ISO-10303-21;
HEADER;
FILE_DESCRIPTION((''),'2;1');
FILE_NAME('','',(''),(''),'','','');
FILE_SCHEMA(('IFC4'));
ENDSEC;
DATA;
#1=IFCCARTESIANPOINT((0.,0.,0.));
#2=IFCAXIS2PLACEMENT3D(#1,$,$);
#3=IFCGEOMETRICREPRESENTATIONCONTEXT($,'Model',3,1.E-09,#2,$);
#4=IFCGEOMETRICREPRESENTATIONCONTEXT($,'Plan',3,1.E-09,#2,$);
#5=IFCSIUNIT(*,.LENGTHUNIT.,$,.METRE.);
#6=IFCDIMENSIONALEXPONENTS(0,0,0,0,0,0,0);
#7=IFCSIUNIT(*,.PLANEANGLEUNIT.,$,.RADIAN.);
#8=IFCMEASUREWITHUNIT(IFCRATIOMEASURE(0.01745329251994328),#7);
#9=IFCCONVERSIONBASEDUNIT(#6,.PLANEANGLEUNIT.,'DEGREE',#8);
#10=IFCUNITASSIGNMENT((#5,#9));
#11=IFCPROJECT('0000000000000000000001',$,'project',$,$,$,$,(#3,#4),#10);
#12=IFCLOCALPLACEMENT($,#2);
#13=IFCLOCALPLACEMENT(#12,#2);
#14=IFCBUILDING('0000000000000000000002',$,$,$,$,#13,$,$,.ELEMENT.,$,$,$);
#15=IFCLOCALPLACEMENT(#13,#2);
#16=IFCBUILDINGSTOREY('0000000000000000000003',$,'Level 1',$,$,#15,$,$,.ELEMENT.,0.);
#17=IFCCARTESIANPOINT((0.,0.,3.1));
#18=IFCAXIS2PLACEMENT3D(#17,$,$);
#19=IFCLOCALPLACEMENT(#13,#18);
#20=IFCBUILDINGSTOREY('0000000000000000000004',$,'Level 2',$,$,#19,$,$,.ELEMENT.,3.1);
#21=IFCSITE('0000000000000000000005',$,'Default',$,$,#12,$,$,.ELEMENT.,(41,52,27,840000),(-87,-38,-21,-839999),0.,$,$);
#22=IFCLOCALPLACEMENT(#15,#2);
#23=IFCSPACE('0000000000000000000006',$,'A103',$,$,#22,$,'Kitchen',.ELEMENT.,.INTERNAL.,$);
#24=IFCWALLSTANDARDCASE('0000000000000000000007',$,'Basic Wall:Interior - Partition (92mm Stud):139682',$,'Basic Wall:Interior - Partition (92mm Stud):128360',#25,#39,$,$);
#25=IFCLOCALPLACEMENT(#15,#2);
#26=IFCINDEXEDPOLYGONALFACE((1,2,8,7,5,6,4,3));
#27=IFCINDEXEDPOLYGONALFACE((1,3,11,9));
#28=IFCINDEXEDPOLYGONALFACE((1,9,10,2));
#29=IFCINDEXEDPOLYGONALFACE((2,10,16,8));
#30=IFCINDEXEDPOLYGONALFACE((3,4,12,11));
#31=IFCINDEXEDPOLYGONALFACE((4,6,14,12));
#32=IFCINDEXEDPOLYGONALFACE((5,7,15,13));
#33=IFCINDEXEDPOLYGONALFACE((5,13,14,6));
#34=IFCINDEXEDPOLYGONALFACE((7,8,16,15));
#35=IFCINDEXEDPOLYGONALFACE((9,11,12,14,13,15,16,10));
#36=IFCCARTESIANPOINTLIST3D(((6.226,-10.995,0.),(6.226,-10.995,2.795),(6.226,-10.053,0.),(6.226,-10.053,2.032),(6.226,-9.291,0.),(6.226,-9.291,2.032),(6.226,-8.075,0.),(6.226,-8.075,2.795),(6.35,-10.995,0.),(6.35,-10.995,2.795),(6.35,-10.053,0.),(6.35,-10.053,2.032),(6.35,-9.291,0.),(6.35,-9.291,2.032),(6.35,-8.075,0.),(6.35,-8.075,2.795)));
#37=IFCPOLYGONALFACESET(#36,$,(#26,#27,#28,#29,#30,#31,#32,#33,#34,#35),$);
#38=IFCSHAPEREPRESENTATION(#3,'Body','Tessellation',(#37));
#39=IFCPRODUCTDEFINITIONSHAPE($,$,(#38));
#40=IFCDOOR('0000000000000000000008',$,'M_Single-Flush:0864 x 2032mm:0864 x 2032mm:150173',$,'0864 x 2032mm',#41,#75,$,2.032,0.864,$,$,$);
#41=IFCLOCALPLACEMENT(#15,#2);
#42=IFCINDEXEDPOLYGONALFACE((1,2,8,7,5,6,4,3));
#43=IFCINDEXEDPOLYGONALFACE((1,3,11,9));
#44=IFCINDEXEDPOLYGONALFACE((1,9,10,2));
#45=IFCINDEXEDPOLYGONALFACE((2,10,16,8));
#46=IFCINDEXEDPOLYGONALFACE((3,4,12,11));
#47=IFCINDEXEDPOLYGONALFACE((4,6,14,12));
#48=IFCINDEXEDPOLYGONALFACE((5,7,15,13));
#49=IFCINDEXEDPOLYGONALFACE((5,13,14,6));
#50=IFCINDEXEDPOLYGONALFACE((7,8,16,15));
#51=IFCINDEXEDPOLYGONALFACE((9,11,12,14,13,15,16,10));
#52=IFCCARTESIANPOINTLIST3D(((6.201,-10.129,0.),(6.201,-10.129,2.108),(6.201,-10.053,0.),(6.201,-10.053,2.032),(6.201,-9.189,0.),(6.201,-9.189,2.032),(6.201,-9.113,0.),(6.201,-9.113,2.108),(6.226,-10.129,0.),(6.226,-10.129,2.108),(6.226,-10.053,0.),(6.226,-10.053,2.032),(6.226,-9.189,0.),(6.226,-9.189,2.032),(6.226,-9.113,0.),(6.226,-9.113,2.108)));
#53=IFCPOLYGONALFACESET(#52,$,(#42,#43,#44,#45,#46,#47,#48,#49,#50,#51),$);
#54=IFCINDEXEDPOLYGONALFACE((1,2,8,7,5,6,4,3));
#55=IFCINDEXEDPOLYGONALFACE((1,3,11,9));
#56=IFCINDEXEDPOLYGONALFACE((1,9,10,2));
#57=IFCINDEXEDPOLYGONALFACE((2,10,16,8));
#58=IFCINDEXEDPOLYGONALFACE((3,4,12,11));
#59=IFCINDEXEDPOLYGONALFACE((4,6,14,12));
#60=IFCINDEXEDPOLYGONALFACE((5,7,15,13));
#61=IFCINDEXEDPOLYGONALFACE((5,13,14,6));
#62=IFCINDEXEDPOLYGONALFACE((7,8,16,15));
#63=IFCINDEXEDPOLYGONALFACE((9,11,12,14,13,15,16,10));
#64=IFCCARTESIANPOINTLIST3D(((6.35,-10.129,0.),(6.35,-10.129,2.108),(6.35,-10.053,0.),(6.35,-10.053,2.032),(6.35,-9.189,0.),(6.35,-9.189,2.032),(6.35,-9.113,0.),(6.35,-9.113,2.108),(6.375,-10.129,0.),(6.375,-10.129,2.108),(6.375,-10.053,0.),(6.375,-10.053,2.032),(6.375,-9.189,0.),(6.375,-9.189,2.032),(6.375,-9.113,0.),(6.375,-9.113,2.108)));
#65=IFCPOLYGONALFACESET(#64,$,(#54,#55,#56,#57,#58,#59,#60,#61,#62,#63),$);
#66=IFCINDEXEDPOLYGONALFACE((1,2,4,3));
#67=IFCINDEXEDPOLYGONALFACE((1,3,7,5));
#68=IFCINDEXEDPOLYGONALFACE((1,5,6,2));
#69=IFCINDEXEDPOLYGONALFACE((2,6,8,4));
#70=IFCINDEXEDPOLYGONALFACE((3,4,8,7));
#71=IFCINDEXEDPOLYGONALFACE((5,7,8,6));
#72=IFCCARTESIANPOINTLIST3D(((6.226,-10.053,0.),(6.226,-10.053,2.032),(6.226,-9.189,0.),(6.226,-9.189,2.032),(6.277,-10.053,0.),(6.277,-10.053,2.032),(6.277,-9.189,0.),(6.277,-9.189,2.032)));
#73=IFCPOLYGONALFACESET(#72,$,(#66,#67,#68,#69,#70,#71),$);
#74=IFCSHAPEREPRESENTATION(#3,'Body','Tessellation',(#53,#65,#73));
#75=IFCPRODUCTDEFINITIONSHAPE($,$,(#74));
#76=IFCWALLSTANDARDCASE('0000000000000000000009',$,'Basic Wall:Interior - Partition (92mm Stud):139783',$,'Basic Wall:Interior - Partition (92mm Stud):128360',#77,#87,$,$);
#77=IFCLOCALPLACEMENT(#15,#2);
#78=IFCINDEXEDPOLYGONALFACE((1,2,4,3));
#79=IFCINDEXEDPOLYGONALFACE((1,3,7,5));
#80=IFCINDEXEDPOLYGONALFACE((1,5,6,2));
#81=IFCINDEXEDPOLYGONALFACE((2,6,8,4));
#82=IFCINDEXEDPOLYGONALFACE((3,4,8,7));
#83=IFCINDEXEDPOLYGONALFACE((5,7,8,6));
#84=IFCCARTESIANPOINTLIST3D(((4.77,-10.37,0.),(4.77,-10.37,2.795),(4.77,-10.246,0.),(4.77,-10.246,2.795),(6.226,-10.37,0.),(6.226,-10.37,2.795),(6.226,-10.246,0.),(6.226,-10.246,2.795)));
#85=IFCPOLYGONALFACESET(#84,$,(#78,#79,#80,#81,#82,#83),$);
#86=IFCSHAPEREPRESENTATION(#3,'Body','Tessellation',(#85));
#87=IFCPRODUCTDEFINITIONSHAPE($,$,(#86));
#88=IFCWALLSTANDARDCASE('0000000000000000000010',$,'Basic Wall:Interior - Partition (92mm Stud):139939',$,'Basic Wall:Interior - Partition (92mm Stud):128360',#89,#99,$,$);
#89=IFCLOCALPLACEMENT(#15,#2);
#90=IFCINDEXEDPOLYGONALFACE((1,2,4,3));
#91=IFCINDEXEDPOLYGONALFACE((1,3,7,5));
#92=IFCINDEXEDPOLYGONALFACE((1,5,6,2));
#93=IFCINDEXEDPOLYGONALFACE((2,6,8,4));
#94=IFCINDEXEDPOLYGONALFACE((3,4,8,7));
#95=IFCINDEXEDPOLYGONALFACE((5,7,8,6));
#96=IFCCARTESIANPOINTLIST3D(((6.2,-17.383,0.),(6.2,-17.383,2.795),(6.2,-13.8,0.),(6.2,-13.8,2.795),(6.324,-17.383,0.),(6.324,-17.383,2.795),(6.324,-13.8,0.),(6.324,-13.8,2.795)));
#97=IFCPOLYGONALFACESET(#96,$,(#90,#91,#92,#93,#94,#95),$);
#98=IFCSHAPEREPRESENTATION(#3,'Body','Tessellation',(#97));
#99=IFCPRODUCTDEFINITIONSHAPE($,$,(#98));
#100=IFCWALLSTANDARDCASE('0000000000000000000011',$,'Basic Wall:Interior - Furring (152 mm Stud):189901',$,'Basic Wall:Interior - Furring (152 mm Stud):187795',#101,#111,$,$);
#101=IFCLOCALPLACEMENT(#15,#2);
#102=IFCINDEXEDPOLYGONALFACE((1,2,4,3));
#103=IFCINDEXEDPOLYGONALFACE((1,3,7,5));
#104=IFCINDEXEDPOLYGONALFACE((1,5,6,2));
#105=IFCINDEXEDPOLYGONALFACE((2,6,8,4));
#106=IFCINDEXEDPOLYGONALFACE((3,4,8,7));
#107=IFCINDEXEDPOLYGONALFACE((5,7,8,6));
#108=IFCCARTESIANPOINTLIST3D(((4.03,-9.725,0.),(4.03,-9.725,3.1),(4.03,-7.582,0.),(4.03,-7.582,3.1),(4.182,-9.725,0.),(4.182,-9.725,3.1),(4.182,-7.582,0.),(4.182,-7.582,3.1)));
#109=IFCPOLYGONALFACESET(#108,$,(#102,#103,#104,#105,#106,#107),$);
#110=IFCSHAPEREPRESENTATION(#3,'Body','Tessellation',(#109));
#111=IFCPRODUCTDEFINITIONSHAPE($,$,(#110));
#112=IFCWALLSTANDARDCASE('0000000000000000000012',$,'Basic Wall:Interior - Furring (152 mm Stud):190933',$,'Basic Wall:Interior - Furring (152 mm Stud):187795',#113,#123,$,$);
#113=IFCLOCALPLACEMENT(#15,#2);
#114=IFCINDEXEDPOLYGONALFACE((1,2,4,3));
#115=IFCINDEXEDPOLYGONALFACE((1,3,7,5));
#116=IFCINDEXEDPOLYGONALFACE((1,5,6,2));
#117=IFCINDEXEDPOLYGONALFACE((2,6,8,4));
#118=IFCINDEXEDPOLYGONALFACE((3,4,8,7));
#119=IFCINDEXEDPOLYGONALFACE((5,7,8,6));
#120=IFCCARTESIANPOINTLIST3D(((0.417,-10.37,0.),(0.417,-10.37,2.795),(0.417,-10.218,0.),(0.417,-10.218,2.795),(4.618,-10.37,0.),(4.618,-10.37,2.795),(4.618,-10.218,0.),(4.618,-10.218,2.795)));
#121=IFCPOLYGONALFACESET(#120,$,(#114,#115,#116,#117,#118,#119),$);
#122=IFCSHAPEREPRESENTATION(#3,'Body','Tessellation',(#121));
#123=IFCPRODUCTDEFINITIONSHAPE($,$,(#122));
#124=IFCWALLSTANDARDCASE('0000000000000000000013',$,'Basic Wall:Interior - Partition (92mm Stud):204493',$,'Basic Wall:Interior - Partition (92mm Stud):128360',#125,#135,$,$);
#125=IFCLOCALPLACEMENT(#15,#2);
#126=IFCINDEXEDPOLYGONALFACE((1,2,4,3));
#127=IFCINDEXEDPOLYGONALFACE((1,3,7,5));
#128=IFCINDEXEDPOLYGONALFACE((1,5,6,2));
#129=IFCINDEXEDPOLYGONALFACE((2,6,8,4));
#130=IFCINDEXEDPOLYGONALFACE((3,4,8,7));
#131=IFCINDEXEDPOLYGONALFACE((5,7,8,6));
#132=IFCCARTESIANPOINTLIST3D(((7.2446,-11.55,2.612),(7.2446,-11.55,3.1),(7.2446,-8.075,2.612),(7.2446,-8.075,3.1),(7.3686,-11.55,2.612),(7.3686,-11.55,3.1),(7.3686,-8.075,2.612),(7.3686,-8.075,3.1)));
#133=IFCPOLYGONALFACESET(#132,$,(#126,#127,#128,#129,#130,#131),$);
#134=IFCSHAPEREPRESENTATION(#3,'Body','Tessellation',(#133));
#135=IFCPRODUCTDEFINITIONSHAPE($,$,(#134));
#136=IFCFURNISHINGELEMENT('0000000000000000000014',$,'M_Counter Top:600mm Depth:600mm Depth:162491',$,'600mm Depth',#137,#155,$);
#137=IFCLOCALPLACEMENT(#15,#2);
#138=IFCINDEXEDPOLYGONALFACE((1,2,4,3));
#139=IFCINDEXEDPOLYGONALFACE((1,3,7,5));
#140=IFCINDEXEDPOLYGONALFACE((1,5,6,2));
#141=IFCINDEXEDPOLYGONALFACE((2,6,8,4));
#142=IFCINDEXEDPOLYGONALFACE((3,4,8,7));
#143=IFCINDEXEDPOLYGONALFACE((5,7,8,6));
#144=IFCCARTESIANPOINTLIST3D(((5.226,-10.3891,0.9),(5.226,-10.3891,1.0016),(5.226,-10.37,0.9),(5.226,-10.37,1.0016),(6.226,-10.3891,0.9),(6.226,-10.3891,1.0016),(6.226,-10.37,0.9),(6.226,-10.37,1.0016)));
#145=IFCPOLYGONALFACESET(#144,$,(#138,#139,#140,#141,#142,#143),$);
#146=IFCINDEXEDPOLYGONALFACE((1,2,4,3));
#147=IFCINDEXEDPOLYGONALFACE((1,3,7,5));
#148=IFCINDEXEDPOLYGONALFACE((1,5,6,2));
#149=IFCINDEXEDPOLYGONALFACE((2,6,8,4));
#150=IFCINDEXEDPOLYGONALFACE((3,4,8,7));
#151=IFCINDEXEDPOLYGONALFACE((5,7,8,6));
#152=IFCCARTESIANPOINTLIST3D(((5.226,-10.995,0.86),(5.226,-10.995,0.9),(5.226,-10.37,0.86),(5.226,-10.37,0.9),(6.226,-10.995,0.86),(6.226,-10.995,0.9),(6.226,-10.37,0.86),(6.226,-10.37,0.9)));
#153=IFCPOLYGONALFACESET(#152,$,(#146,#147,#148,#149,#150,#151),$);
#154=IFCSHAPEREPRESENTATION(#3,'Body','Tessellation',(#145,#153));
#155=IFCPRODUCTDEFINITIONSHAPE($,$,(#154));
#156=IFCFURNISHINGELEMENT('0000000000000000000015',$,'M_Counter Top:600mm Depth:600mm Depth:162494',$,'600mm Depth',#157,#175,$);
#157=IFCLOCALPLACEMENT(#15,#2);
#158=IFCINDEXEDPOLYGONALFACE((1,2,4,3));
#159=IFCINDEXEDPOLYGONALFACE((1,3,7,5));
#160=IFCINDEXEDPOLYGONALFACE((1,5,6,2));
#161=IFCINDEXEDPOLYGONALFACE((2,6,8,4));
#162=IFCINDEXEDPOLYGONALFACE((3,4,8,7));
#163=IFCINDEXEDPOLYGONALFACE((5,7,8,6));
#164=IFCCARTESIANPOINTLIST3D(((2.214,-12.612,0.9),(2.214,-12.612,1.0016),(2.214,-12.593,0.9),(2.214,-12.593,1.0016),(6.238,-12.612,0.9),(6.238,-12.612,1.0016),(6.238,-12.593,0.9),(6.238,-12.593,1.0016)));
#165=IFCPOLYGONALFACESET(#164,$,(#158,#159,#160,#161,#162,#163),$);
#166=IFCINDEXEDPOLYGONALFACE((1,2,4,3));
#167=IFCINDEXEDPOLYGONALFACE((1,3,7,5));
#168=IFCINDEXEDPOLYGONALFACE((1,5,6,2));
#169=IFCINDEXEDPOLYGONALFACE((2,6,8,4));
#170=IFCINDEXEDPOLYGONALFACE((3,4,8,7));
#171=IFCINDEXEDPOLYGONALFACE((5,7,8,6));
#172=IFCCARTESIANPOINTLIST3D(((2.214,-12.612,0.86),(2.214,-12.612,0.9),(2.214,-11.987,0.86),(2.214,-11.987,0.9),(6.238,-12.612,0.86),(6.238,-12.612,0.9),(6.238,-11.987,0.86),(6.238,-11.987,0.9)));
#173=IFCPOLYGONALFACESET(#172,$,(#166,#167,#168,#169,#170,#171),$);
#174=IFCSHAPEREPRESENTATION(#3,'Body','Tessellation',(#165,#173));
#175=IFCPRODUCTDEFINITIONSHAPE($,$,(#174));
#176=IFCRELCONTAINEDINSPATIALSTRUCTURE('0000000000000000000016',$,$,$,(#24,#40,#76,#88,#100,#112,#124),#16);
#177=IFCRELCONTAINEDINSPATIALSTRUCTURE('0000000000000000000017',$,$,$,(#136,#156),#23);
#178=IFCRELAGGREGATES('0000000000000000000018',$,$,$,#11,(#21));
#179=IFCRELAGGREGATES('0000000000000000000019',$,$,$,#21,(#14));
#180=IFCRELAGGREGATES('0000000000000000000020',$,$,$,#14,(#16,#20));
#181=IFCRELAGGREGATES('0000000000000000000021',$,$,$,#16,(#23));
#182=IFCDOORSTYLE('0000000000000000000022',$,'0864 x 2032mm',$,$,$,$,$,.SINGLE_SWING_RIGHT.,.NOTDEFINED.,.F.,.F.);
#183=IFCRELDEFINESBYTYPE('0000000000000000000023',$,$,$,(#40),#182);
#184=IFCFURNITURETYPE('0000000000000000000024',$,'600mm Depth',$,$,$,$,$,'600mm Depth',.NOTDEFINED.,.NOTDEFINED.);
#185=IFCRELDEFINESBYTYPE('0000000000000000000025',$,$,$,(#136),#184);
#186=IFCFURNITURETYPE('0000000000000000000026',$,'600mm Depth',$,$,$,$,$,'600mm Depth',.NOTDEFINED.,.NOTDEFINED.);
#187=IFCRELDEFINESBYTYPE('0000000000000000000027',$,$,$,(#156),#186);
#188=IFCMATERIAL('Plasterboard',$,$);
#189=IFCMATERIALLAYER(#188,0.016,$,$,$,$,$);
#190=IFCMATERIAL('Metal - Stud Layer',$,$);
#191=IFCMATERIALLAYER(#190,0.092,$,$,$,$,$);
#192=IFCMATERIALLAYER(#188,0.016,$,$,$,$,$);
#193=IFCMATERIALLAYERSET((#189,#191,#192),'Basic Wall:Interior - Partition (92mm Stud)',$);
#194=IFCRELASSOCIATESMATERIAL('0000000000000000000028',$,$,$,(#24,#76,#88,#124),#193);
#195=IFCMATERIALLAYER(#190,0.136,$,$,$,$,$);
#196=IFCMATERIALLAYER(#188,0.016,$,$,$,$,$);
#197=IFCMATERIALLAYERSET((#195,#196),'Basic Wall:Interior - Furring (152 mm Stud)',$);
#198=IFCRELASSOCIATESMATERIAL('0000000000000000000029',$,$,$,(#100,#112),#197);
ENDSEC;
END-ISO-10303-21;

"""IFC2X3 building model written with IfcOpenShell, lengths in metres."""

from ifc_helpers import new_model, entity, si_unit, converted_unit, frame, frame_2d, origin, origin_2d_with_axis, place, context, project, spatial, polyline, rectangle, outline, extrude, source, transform, mapped, material, layer, layer_set, layer_usage, type_object, type_shapes, element, fill, save


model = new_model("IFC2X3")

# Units and contexts
model_context = context("Model", 3, precision=1e-09, world=origin())
plan_context = context("Plan", 3, precision=1e-09, world=origin())
ifc_project = project(units=[si_unit("LENGTHUNIT", "METRE"), converted_unit("PLANEANGLEUNIT", "DEGREE", entity("IfcRatioMeasure", 0.01745329251994328), si_unit("PLANEANGLEUNIT", "RADIAN"), dimensions=[0, 0, 0, 0, 0, 0, 0])], contexts=[model_context, plan_context])

# Site, building, storey
site_placement = place(None, origin())
site = spatial("IfcSite", under=ifc_project, at=site_placement, Name="Default", CompositionType="ELEMENT", RefLatitude=(41, 52, 27, 840000), RefLongitude=(-87, -38, -21, -839999), RefElevation=0.0)
building_placement = place(site_placement, origin())
building = spatial("IfcBuilding", under=site, at=building_placement, CompositionType="ELEMENT")
storey_1_placement = place(building_placement, origin())
storey_1 = spatial("IfcBuildingStorey", under=building, at=storey_1_placement, Name="Level 1", CompositionType="ELEMENT", Elevation=0.0)

# Shared definitions
ifc_material_1 = material(Name="Metal - Stud Layer")
ifc_material_2 = material(Name="Plasterboard")

# Wall, opening, door
ifc_layer_1 = layer(ifc_material_2, 0.016)
ifc_layer_2 = layer(ifc_material_1, 0.092)
ifc_layer_3 = layer(ifc_material_2, 0.016)
ifc_layer_set_1 = layer_set([ifc_layer_1, ifc_layer_2, ifc_layer_3], Name="Basic Wall:Interior - Partition (92mm Stud)")
ifc_layer_usage_1 = layer_usage(ifc_layer_set_1, "AXIS2", "NEGATIVE", 0.062)
wall_1_placement = place(storey_1_placement, frame((6.288, -10.995, 0.0), z_axis=(0.0, 0.0, 1.0), x_axis=(0.0, 1.0, 0.0)))
wall_1 = element("IfcWallStandardCase", 1, at=wall_1_placement, inside=storey_1, material=ifc_layer_usage_1, Name="Basic Wall:Interior - Partition (92mm Stud):139682", ObjectType="Basic Wall:Interior - Partition (92mm Stud):128360", context=model_context, shape_type="SweptSolid", body=[
    extrude(rectangle(XDim=2.92, YDim=0.124, at=frame_2d((1.46, 0.0), x_axis=(-1.0, 0.0))), origin(), (0.0, 0.0, 1.0), 2.795),
])
opening_1_placement = place(wall_1_placement, frame((0.942, -0.062, 0.0)))
opening_1 = element("IfcOpeningElement", 2, at=opening_1_placement, cuts=wall_1, ObjectType="Opening", context=model_context, shape_type="SweptSolid", body=[
    extrude(rectangle(XDim=0.762, YDim=2.032, at=frame_2d((1.016, 0.381), x_axis=(0.0, -1.0))), frame((0.0, 0.0, 0.0), z_axis=(0.0, 1.0, 0.0), x_axis=(0.0, 0.0, 1.0)), (0.0, 0.0, 1.0), 0.124),
])
door_style_1 = type_object("IfcDoorStyle", Name="0864 x 2032mm", ConstructionType="NOTDEFINED", OperationType="SINGLE_SWING_RIGHT", ParameterTakesPrecedence=False, Sizeable=False)
shared_shape_1 = source(origin(), model_context, "Body", "SweptSolid", [
    extrude(outline(polyline([(-0.508, -1.073), (0.508, -1.073), (0.508, 1.035), (0.432, 1.035), (0.432, -0.997), (-0.432, -0.997), (-0.432, 1.035), (-0.508, 1.035), (-0.508, -1.073)])), frame((0.432, 0.124, 1.035), z_axis=(0.0, 1.0, 0.0), x_axis=(1.0, 0.0, 0.0)), (0.0, 0.0, 1.0), 0.025),
    extrude(outline(polyline([(-1.073, -0.508), (1.035, -0.508), (1.035, -0.432), (-0.997, -0.432), (-0.997, 0.432), (1.035, 0.432), (1.035, 0.508), (-1.073, 0.508), (-1.073, -0.508)])), frame((0.432, -0.025, 1.035), z_axis=(0.0, 1.0, 0.0), x_axis=(0.0, 0.0, -1.0)), (0.0, 0.0, 1.0), 0.025),
    extrude(rectangle(XDim=0.051, YDim=0.864, at=origin_2d_with_axis()), frame((0.432, 0.0985, 0.0), z_axis=(0.0, 0.0, 1.0), x_axis=(0.0, 1.0, 0.0)), (0.0, 0.0, 1.0), 2.032),
])
type_shapes(door_style_1, [shared_shape_1])
door_1_placement = place(opening_1_placement, origin())
door_1 = element("IfcDoor", 3, at=door_1_placement, inside=storey_1, type_object=door_style_1, Name="M_Single-Flush:0864 x 2032mm:0864 x 2032mm:150173", ObjectType="0864 x 2032mm", OverallHeight=2.032, OverallWidth=0.864, context=model_context, shape_type="MappedRepresentation", body=[
    mapped(shared_shape_1, transform((0.0, 0.0, 0.0), x_axis=(1.0, 0.0, 0.0), y_axis=(0.0, 1.0, 0.0), z_axis=(0.0, 0.0, 1.0), scale=1.0)),
])
fill(opening_1, door_1)

# Walls
ifc_layer_usage_2 = layer_usage(ifc_layer_set_1, "AXIS2", "NEGATIVE", 0.062)
wall_2_placement = place(storey_1_placement, frame((4.77, -10.308, 0.0)))
element("IfcWallStandardCase", 4, at=wall_2_placement, inside=storey_1, material=ifc_layer_usage_2, Name="Basic Wall:Interior - Partition (92mm Stud):139783", ObjectType="Basic Wall:Interior - Partition (92mm Stud):128360", context=model_context, shape_type="SweptSolid", body=[
    extrude(rectangle(XDim=1.456, YDim=0.124, at=frame_2d((0.728, 0.0), x_axis=(-1.0, 0.0))), origin(), (0.0, 0.0, 1.0), 2.795),
])
ifc_layer_usage_3 = layer_usage(ifc_layer_set_1, "AXIS2", "NEGATIVE", 0.062)
wall_3_placement = place(storey_1_placement, frame((6.262, -13.8, 0.0), z_axis=(0.0, 0.0, 1.0), x_axis=(0.0, -1.0, 0.0)))
element("IfcWallStandardCase", 5, at=wall_3_placement, inside=storey_1, material=ifc_layer_usage_3, Name="Basic Wall:Interior - Partition (92mm Stud):139939", ObjectType="Basic Wall:Interior - Partition (92mm Stud):128360", context=model_context, shape_type="SweptSolid", body=[
    extrude(rectangle(XDim=3.583, YDim=0.124, at=frame_2d((1.7915, 0.0), x_axis=(-1.0, 0.0))), origin(), (0.0, 0.0, 1.0), 2.795),
])

# Shared definitions
storey_2_placement = place(building_placement, frame((0.0, 0.0, 3.1)))
storey_2 = spatial("IfcBuildingStorey", under=building, at=storey_2_placement, Name="Level 2", CompositionType="ELEMENT", Elevation=3.1)

# Walls
ifc_layer_4 = layer(ifc_material_1, 0.136)
ifc_layer_5 = layer(ifc_material_2, 0.016)
ifc_layer_set_2 = layer_set([ifc_layer_4, ifc_layer_5], Name="Basic Wall:Interior - Furring (152 mm Stud)")
ifc_layer_usage_4 = layer_usage(ifc_layer_set_2, "AXIS2", "POSITIVE", -0.076)
wall_4_placement = place(storey_1_placement, frame((4.106, -9.725, 0.0), z_axis=(0.0, 0.0, 1.0), x_axis=(0.0, 1.0, 0.0)))
element("IfcWallStandardCase", 6, at=wall_4_placement, inside=storey_1, material=ifc_layer_usage_4, Name="Basic Wall:Interior - Furring (152 mm Stud):189901", ObjectType="Basic Wall:Interior - Furring (152 mm Stud):187795", context=model_context, shape_type="SweptSolid", body=[
    extrude(rectangle(XDim=2.143, YDim=0.152, at=frame_2d((1.0715, 0.0), x_axis=(-1.0, 0.0))), origin(), (0.0, 0.0, 1.0), 3.1),
])
ifc_layer_usage_5 = layer_usage(ifc_layer_set_2, "AXIS2", "NEGATIVE", 0.076)
wall_5_placement = place(storey_1_placement, frame((0.417, -10.294, 0.0)))
element("IfcWallStandardCase", 7, at=wall_5_placement, inside=storey_1, material=ifc_layer_usage_5, Name="Basic Wall:Interior - Furring (152 mm Stud):190933", ObjectType="Basic Wall:Interior - Furring (152 mm Stud):187795", context=model_context, shape_type="SweptSolid", body=[
    extrude(rectangle(XDim=4.201, YDim=0.152, at=frame_2d((2.1005, 0.0), x_axis=(-1.0, 0.0))), origin(), (0.0, 0.0, 1.0), 2.795),
])
ifc_layer_usage_6 = layer_usage(ifc_layer_set_1, "AXIS2", "NEGATIVE", 0.062)
wall_6_placement = place(storey_1_placement, frame((7.3066, -11.55, 2.612), z_axis=(0.0, 0.0, 1.0), x_axis=(0.0, 1.0, 0.0)))
element("IfcWallStandardCase", 8, at=wall_6_placement, inside=storey_1, material=ifc_layer_usage_6, Name="Basic Wall:Interior - Partition (92mm Stud):204493", ObjectType="Basic Wall:Interior - Partition (92mm Stud):128360", context=model_context, shape_type="SweptSolid", body=[
    extrude(rectangle(XDim=3.475, YDim=0.124, at=frame_2d((1.7375, 0.0), x_axis=(-1.0, 0.0))), origin(), (0.0, 0.0, 1.0), 0.488),
])

# Shared definitions
space_1_placement = place(storey_1_placement, origin())
space_1 = spatial("IfcSpace", under=storey_1, at=space_1_placement, Name="A103", LongName="Kitchen", CompositionType="ELEMENT", InteriorOrExteriorSpace="INTERNAL")

# Furnishing elements
furniture_type_1 = type_object("IfcFurnitureType", Name="600mm Depth", ElementType="600mm Depth", AssemblyPlace="NOTDEFINED")
shared_shape_2 = source(origin(), model_context, "Body", "SweptSolid", [
    extrude(rectangle(XDim=0.0191, YDim=1.0, at=origin_2d_with_axis()), frame((-0.7005, -0.0095, 0.9), z_axis=(0.0, 0.0, 1.0), x_axis=(0.0, -1.0, 0.0)), (0.0, 0.0, 1.0), 0.1016),
    extrude(rectangle(XDim=1.0, YDim=0.625, at=origin_2d_with_axis()), frame((-0.7005, -0.3125, 0.86), z_axis=(0.0, 0.0, 1.0), x_axis=(-1.0, 0.0, 0.0)), (0.0, 0.0, 1.0), 0.04),
])
type_shapes(furniture_type_1, [shared_shape_2])
furnishing_1_placement = place(space_1_placement, frame((6.4265, -10.37, 0.0)))
element("IfcFurnishingElement", 9, at=furnishing_1_placement, inside=space_1, type_object=furniture_type_1, Name="M_Counter Top:600mm Depth:600mm Depth:162491", ObjectType="600mm Depth", context=model_context, shape_type="MappedRepresentation", body=[
    mapped(shared_shape_2, transform((0.0, 0.0, 0.0), scale=1.0)),
])
furniture_type_2 = type_object("IfcFurnitureType", Name="600mm Depth", ElementType="600mm Depth", AssemblyPlace="NOTDEFINED")
shared_shape_3 = source(origin(), model_context, "Body", "SweptSolid", [
    extrude(rectangle(XDim=0.0191, YDim=4.024, at=origin_2d_with_axis()), frame((0.8115, -0.0095, 0.9), z_axis=(0.0, 0.0, 1.0), x_axis=(0.0, -1.0, 0.0)), (0.0, 0.0, 1.0), 0.1016),
    extrude(rectangle(XDim=4.024, YDim=0.625, at=origin_2d_with_axis()), frame((0.8115, -0.3125, 0.86), z_axis=(0.0, 0.0, 1.0), x_axis=(-1.0, 0.0, 0.0)), (0.0, 0.0, 1.0), 0.04),
])
type_shapes(furniture_type_2, [shared_shape_3])
furnishing_2_placement = place(space_1_placement, frame((5.0375, -12.612, 0.0), z_axis=(0.0, 0.0, 1.0), x_axis=(-1.0, 0.0, 0.0)))
element("IfcFurnishingElement", 10, at=furnishing_2_placement, inside=space_1, type_object=furniture_type_2, Name="M_Counter Top:600mm Depth:600mm Depth:162494", ObjectType="600mm Depth", context=model_context, shape_type="MappedRepresentation", body=[
    mapped(shared_shape_3, transform((0.0, 0.0, 0.0), scale=1.0)),
])

save(model, "model.ifc")
